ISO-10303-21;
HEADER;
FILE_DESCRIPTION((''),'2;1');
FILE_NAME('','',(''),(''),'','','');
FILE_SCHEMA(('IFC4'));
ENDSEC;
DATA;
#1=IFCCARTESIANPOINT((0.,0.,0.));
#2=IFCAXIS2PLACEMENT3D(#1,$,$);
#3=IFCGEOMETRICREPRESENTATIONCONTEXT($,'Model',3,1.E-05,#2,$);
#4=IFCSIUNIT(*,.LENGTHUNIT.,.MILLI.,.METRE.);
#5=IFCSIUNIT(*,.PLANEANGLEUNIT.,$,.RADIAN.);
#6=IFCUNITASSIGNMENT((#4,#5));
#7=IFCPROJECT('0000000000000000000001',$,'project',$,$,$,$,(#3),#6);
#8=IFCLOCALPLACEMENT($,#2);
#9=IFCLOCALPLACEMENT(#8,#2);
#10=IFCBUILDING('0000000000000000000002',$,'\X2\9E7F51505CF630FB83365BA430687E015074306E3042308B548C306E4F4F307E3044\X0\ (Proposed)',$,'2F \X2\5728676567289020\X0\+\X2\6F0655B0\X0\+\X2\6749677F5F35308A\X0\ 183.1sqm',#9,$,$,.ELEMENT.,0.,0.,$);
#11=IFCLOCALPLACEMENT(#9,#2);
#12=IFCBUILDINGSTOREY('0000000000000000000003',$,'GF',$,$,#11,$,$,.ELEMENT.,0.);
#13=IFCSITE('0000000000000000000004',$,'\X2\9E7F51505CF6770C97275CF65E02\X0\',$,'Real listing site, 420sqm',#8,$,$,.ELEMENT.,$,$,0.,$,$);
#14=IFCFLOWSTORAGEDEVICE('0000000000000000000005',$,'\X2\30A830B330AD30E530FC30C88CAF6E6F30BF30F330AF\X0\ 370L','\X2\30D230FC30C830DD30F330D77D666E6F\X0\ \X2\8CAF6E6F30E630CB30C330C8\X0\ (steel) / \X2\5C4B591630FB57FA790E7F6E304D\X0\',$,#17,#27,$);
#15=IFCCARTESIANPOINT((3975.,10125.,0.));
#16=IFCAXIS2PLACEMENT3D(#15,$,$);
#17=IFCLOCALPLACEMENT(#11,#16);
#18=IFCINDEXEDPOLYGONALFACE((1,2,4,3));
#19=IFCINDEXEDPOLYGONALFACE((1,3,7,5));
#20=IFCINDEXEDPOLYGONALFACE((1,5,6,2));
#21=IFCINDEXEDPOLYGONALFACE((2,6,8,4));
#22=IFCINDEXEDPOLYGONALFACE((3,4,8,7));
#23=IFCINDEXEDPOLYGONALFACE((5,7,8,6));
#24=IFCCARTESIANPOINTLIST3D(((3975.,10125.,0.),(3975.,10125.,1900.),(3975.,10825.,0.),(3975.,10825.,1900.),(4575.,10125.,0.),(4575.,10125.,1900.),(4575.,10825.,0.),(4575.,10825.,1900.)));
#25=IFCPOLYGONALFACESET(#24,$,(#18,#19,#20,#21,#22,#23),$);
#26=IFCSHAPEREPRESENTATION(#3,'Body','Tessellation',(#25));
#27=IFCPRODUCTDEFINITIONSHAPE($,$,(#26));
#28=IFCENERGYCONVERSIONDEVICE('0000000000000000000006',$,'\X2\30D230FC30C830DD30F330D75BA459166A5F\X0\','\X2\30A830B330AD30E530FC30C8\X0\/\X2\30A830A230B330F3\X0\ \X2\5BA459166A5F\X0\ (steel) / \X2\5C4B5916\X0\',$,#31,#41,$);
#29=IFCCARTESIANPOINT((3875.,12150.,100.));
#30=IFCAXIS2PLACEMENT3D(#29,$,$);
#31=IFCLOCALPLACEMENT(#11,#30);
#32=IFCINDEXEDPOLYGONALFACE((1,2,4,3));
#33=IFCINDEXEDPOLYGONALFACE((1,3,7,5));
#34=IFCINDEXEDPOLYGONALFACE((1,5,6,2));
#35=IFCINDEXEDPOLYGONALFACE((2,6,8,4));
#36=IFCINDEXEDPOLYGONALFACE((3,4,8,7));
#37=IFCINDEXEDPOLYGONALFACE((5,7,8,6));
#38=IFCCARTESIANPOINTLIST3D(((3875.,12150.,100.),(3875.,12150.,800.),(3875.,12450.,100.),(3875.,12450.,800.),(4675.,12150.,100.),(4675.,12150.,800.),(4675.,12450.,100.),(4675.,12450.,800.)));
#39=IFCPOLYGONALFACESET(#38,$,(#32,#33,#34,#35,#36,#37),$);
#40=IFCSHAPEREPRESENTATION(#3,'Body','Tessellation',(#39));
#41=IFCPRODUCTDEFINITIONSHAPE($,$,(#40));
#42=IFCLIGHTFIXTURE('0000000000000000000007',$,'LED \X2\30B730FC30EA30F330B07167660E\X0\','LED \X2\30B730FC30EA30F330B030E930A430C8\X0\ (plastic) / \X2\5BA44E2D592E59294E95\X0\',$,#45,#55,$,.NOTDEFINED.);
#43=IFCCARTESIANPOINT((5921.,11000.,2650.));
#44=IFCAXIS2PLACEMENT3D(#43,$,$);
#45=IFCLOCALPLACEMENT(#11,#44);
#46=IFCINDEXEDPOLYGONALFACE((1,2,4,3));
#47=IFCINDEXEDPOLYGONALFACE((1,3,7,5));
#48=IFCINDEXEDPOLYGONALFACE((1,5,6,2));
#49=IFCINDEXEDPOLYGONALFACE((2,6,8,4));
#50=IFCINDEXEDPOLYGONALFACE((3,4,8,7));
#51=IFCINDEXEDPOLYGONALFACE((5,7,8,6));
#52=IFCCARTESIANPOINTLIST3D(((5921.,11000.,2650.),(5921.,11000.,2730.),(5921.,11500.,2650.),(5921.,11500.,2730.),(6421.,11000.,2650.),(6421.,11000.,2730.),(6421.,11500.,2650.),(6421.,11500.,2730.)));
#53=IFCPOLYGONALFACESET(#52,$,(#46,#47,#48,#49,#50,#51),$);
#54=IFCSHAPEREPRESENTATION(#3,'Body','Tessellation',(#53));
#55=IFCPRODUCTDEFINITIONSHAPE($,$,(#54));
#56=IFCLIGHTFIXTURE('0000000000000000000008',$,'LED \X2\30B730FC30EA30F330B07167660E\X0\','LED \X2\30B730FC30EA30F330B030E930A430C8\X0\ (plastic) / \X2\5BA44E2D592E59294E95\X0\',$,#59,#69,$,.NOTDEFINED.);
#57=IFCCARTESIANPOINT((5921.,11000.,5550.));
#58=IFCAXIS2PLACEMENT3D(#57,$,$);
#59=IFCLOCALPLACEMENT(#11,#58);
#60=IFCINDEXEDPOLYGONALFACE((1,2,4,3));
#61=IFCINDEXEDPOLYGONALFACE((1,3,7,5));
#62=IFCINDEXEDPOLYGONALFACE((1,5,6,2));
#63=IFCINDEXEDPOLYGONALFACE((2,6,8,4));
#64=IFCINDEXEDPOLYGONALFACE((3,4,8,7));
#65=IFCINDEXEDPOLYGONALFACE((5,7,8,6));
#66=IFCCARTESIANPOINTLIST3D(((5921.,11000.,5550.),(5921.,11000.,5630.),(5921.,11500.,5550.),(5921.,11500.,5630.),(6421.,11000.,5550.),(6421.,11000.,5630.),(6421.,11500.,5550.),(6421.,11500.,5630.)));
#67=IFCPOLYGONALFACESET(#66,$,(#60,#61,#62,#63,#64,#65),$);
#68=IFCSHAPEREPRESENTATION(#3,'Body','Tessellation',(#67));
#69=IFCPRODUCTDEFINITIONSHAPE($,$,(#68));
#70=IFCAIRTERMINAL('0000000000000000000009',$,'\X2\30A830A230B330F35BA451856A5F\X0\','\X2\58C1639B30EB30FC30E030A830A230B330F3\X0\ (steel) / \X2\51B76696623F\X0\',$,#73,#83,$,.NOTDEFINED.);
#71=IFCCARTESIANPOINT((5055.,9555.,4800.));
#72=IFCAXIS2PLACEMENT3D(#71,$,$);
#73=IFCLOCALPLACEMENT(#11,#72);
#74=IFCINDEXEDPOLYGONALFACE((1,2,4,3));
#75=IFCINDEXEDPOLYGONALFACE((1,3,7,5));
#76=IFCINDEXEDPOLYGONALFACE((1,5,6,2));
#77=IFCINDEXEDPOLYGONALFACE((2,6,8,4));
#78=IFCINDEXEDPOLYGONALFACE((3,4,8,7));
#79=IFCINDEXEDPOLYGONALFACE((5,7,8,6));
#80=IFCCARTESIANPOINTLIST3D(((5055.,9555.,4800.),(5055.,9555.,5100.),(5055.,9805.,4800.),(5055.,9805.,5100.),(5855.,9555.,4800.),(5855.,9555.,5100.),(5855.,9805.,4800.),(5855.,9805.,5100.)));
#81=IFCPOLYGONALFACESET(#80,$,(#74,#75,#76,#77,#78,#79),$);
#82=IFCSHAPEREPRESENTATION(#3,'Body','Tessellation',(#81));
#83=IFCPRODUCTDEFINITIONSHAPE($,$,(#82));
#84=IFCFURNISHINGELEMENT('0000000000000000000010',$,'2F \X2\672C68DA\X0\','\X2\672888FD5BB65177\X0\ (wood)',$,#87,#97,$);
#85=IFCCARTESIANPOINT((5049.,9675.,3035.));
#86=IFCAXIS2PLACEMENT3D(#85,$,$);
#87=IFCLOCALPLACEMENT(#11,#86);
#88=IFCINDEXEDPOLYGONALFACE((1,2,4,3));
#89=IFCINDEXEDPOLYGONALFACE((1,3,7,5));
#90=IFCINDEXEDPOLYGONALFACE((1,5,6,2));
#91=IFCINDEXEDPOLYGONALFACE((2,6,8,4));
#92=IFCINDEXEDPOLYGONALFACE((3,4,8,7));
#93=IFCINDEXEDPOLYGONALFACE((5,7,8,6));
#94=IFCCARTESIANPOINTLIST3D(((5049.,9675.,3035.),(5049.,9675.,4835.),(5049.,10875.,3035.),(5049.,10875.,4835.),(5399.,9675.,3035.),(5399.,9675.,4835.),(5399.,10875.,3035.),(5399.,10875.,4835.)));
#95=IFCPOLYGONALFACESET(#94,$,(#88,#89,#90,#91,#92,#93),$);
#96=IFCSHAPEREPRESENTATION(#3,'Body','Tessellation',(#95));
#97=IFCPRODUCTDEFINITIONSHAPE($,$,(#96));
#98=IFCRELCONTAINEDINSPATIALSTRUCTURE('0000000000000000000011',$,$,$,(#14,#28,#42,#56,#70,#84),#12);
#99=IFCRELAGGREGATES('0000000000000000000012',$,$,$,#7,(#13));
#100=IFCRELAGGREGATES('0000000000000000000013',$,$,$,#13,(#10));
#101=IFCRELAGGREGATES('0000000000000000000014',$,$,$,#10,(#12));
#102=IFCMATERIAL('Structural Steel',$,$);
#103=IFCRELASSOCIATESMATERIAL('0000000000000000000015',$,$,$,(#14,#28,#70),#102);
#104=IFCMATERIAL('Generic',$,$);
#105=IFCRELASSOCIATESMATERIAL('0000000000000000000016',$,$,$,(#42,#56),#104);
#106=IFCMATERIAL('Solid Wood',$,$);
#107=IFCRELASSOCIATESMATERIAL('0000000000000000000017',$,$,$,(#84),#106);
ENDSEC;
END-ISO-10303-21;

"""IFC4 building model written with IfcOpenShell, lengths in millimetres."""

from ifc_helpers import new_model, si_unit, frame, frame_2d, origin, place, context, project, spatial, rectangle, extrude, material, element, save


model = new_model("IFC4")

# Units and contexts
model_context = context("Model", 3, precision=1e-05, world=origin())
ifc_project = project(units=[si_unit("LENGTHUNIT", "METRE", prefix="MILLI"), si_unit("PLANEANGLEUNIT", "RADIAN")], contexts=[model_context])

# Site, building, storey
site_placement = place(None, origin())
site = spatial("IfcSite", under=ifc_project, at=site_placement, Name="鹿児島県霧島市", ObjectType="Real listing site, 420sqm", CompositionType="ELEMENT", RefElevation=0.0)
building_placement = place(site_placement, origin())
building = spatial("IfcBuilding", under=site, at=building_placement, Name="鹿児島・茶室と縁側のある和の住まい (Proposed)", ObjectType="2F 在来木造+漆喰+杉板張り 183.1sqm", CompositionType="ELEMENT", ElevationOfRefHeight=0.0, ElevationOfTerrain=0.0)
storey_placement = place(building_placement, origin())
storey = spatial("IfcBuildingStorey", under=building, at=storey_placement, Name="GF", CompositionType="ELEMENT", Elevation=0.0)

# Shared definitions
ifc_material_1 = material(Name="Solid Wood")

# Shared definitions
ifc_material_2 = material(Name="Structural Steel")

# Shared definitions
ifc_material_3 = material(Name="Generic")

# Flow storage device
flow_storage_device_placement = place(storey_placement, frame((3975.0, 10125.0, 0.0)))
element("IfcFlowStorageDevice", 1, at=flow_storage_device_placement, inside=storey, material=ifc_material_2, Name="エコキュート貯湯タンク 370L", Description="ヒートポンプ給湯 貯湯ユニット (steel) / 屋外・基礎置き", context=model_context, shape_type="SweptSolid", body=[
    extrude(rectangle(XDim=600.0, YDim=700.0, at=frame_2d((300.0, 350.0))), frame((3975.0, 10125.0, 0.0)), (0.0, 0.0, 1.0), 1900.0),
])

# Energy conversion device
energy_conversion_device_placement = place(storey_placement, frame((3875.0, 12150.0, 100.0)))
element("IfcEnergyConversionDevice", 2, at=energy_conversion_device_placement, inside=storey, material=ifc_material_2, Name="ヒートポンプ室外機", Description="エコキュート/エアコン 室外機 (steel) / 屋外", context=model_context, shape_type="SweptSolid", body=[
    extrude(rectangle(XDim=800.0, YDim=300.0, at=frame_2d((400.0, 150.0))), frame((3875.0, 12150.0, 100.0)), (0.0, 0.0, 1.0), 700.0),
])

# Light fixtures
light_fixture_1_placement = place(storey_placement, frame((5921.0, 11000.0, 2650.0)))
element("IfcLightFixture", 3, at=light_fixture_1_placement, inside=storey, material=ifc_material_3, Name="LED シーリング照明", Description="LED シーリングライト (plastic) / 室中央天井", PredefinedType="NOTDEFINED", context=model_context, shape_type="SweptSolid", body=[
    extrude(rectangle(XDim=500.0, YDim=500.0, at=frame_2d((250.0, 250.0))), frame((5921.0, 11000.0, 2650.0)), (0.0, 0.0, 1.0), 80.0),
])
light_fixture_2_placement = place(storey_placement, frame((5921.0, 11000.0, 5550.0)))
element("IfcLightFixture", 4, at=light_fixture_2_placement, inside=storey, material=ifc_material_3, Name="LED シーリング照明", Description="LED シーリングライト (plastic) / 室中央天井", PredefinedType="NOTDEFINED", context=model_context, shape_type="SweptSolid", body=[
    extrude(rectangle(XDim=500.0, YDim=500.0, at=frame_2d((250.0, 250.0))), frame((5921.0, 11000.0, 5550.0)), (0.0, 0.0, 1.0), 80.0),
])

# Air terminal
air_terminal_placement = place(storey_placement, frame((5055.0, 9555.0, 4800.0)))
element("IfcAirTerminal", 5, at=air_terminal_placement, inside=storey, material=ifc_material_2, Name="エアコン室内機", Description="壁掛ルームエアコン (steel) / 冷暖房", PredefinedType="NOTDEFINED", context=model_context, shape_type="SweptSolid", body=[
    extrude(rectangle(XDim=800.0, YDim=250.0, at=frame_2d((400.0, 125.0))), frame((5055.0, 9555.0, 4800.0)), (0.0, 0.0, 1.0), 300.0),
])

# Furnishing element
furnishing_placement = place(storey_placement, frame((5049.0, 9675.0, 3035.0)))
element("IfcFurnishingElement", 6, at=furnishing_placement, inside=storey, material=ifc_material_1, Name="2F 本棚", Description="木製家具 (wood)", context=model_context, shape_type="SweptSolid", body=[
    extrude(rectangle(XDim=350.0, YDim=1200.0, at=frame_2d((175.0, 600.0))), frame((5049.0, 9675.0, 3035.0)), (0.0, 0.0, 1.0), 1800.0),
])

save(model, "model.ifc")
